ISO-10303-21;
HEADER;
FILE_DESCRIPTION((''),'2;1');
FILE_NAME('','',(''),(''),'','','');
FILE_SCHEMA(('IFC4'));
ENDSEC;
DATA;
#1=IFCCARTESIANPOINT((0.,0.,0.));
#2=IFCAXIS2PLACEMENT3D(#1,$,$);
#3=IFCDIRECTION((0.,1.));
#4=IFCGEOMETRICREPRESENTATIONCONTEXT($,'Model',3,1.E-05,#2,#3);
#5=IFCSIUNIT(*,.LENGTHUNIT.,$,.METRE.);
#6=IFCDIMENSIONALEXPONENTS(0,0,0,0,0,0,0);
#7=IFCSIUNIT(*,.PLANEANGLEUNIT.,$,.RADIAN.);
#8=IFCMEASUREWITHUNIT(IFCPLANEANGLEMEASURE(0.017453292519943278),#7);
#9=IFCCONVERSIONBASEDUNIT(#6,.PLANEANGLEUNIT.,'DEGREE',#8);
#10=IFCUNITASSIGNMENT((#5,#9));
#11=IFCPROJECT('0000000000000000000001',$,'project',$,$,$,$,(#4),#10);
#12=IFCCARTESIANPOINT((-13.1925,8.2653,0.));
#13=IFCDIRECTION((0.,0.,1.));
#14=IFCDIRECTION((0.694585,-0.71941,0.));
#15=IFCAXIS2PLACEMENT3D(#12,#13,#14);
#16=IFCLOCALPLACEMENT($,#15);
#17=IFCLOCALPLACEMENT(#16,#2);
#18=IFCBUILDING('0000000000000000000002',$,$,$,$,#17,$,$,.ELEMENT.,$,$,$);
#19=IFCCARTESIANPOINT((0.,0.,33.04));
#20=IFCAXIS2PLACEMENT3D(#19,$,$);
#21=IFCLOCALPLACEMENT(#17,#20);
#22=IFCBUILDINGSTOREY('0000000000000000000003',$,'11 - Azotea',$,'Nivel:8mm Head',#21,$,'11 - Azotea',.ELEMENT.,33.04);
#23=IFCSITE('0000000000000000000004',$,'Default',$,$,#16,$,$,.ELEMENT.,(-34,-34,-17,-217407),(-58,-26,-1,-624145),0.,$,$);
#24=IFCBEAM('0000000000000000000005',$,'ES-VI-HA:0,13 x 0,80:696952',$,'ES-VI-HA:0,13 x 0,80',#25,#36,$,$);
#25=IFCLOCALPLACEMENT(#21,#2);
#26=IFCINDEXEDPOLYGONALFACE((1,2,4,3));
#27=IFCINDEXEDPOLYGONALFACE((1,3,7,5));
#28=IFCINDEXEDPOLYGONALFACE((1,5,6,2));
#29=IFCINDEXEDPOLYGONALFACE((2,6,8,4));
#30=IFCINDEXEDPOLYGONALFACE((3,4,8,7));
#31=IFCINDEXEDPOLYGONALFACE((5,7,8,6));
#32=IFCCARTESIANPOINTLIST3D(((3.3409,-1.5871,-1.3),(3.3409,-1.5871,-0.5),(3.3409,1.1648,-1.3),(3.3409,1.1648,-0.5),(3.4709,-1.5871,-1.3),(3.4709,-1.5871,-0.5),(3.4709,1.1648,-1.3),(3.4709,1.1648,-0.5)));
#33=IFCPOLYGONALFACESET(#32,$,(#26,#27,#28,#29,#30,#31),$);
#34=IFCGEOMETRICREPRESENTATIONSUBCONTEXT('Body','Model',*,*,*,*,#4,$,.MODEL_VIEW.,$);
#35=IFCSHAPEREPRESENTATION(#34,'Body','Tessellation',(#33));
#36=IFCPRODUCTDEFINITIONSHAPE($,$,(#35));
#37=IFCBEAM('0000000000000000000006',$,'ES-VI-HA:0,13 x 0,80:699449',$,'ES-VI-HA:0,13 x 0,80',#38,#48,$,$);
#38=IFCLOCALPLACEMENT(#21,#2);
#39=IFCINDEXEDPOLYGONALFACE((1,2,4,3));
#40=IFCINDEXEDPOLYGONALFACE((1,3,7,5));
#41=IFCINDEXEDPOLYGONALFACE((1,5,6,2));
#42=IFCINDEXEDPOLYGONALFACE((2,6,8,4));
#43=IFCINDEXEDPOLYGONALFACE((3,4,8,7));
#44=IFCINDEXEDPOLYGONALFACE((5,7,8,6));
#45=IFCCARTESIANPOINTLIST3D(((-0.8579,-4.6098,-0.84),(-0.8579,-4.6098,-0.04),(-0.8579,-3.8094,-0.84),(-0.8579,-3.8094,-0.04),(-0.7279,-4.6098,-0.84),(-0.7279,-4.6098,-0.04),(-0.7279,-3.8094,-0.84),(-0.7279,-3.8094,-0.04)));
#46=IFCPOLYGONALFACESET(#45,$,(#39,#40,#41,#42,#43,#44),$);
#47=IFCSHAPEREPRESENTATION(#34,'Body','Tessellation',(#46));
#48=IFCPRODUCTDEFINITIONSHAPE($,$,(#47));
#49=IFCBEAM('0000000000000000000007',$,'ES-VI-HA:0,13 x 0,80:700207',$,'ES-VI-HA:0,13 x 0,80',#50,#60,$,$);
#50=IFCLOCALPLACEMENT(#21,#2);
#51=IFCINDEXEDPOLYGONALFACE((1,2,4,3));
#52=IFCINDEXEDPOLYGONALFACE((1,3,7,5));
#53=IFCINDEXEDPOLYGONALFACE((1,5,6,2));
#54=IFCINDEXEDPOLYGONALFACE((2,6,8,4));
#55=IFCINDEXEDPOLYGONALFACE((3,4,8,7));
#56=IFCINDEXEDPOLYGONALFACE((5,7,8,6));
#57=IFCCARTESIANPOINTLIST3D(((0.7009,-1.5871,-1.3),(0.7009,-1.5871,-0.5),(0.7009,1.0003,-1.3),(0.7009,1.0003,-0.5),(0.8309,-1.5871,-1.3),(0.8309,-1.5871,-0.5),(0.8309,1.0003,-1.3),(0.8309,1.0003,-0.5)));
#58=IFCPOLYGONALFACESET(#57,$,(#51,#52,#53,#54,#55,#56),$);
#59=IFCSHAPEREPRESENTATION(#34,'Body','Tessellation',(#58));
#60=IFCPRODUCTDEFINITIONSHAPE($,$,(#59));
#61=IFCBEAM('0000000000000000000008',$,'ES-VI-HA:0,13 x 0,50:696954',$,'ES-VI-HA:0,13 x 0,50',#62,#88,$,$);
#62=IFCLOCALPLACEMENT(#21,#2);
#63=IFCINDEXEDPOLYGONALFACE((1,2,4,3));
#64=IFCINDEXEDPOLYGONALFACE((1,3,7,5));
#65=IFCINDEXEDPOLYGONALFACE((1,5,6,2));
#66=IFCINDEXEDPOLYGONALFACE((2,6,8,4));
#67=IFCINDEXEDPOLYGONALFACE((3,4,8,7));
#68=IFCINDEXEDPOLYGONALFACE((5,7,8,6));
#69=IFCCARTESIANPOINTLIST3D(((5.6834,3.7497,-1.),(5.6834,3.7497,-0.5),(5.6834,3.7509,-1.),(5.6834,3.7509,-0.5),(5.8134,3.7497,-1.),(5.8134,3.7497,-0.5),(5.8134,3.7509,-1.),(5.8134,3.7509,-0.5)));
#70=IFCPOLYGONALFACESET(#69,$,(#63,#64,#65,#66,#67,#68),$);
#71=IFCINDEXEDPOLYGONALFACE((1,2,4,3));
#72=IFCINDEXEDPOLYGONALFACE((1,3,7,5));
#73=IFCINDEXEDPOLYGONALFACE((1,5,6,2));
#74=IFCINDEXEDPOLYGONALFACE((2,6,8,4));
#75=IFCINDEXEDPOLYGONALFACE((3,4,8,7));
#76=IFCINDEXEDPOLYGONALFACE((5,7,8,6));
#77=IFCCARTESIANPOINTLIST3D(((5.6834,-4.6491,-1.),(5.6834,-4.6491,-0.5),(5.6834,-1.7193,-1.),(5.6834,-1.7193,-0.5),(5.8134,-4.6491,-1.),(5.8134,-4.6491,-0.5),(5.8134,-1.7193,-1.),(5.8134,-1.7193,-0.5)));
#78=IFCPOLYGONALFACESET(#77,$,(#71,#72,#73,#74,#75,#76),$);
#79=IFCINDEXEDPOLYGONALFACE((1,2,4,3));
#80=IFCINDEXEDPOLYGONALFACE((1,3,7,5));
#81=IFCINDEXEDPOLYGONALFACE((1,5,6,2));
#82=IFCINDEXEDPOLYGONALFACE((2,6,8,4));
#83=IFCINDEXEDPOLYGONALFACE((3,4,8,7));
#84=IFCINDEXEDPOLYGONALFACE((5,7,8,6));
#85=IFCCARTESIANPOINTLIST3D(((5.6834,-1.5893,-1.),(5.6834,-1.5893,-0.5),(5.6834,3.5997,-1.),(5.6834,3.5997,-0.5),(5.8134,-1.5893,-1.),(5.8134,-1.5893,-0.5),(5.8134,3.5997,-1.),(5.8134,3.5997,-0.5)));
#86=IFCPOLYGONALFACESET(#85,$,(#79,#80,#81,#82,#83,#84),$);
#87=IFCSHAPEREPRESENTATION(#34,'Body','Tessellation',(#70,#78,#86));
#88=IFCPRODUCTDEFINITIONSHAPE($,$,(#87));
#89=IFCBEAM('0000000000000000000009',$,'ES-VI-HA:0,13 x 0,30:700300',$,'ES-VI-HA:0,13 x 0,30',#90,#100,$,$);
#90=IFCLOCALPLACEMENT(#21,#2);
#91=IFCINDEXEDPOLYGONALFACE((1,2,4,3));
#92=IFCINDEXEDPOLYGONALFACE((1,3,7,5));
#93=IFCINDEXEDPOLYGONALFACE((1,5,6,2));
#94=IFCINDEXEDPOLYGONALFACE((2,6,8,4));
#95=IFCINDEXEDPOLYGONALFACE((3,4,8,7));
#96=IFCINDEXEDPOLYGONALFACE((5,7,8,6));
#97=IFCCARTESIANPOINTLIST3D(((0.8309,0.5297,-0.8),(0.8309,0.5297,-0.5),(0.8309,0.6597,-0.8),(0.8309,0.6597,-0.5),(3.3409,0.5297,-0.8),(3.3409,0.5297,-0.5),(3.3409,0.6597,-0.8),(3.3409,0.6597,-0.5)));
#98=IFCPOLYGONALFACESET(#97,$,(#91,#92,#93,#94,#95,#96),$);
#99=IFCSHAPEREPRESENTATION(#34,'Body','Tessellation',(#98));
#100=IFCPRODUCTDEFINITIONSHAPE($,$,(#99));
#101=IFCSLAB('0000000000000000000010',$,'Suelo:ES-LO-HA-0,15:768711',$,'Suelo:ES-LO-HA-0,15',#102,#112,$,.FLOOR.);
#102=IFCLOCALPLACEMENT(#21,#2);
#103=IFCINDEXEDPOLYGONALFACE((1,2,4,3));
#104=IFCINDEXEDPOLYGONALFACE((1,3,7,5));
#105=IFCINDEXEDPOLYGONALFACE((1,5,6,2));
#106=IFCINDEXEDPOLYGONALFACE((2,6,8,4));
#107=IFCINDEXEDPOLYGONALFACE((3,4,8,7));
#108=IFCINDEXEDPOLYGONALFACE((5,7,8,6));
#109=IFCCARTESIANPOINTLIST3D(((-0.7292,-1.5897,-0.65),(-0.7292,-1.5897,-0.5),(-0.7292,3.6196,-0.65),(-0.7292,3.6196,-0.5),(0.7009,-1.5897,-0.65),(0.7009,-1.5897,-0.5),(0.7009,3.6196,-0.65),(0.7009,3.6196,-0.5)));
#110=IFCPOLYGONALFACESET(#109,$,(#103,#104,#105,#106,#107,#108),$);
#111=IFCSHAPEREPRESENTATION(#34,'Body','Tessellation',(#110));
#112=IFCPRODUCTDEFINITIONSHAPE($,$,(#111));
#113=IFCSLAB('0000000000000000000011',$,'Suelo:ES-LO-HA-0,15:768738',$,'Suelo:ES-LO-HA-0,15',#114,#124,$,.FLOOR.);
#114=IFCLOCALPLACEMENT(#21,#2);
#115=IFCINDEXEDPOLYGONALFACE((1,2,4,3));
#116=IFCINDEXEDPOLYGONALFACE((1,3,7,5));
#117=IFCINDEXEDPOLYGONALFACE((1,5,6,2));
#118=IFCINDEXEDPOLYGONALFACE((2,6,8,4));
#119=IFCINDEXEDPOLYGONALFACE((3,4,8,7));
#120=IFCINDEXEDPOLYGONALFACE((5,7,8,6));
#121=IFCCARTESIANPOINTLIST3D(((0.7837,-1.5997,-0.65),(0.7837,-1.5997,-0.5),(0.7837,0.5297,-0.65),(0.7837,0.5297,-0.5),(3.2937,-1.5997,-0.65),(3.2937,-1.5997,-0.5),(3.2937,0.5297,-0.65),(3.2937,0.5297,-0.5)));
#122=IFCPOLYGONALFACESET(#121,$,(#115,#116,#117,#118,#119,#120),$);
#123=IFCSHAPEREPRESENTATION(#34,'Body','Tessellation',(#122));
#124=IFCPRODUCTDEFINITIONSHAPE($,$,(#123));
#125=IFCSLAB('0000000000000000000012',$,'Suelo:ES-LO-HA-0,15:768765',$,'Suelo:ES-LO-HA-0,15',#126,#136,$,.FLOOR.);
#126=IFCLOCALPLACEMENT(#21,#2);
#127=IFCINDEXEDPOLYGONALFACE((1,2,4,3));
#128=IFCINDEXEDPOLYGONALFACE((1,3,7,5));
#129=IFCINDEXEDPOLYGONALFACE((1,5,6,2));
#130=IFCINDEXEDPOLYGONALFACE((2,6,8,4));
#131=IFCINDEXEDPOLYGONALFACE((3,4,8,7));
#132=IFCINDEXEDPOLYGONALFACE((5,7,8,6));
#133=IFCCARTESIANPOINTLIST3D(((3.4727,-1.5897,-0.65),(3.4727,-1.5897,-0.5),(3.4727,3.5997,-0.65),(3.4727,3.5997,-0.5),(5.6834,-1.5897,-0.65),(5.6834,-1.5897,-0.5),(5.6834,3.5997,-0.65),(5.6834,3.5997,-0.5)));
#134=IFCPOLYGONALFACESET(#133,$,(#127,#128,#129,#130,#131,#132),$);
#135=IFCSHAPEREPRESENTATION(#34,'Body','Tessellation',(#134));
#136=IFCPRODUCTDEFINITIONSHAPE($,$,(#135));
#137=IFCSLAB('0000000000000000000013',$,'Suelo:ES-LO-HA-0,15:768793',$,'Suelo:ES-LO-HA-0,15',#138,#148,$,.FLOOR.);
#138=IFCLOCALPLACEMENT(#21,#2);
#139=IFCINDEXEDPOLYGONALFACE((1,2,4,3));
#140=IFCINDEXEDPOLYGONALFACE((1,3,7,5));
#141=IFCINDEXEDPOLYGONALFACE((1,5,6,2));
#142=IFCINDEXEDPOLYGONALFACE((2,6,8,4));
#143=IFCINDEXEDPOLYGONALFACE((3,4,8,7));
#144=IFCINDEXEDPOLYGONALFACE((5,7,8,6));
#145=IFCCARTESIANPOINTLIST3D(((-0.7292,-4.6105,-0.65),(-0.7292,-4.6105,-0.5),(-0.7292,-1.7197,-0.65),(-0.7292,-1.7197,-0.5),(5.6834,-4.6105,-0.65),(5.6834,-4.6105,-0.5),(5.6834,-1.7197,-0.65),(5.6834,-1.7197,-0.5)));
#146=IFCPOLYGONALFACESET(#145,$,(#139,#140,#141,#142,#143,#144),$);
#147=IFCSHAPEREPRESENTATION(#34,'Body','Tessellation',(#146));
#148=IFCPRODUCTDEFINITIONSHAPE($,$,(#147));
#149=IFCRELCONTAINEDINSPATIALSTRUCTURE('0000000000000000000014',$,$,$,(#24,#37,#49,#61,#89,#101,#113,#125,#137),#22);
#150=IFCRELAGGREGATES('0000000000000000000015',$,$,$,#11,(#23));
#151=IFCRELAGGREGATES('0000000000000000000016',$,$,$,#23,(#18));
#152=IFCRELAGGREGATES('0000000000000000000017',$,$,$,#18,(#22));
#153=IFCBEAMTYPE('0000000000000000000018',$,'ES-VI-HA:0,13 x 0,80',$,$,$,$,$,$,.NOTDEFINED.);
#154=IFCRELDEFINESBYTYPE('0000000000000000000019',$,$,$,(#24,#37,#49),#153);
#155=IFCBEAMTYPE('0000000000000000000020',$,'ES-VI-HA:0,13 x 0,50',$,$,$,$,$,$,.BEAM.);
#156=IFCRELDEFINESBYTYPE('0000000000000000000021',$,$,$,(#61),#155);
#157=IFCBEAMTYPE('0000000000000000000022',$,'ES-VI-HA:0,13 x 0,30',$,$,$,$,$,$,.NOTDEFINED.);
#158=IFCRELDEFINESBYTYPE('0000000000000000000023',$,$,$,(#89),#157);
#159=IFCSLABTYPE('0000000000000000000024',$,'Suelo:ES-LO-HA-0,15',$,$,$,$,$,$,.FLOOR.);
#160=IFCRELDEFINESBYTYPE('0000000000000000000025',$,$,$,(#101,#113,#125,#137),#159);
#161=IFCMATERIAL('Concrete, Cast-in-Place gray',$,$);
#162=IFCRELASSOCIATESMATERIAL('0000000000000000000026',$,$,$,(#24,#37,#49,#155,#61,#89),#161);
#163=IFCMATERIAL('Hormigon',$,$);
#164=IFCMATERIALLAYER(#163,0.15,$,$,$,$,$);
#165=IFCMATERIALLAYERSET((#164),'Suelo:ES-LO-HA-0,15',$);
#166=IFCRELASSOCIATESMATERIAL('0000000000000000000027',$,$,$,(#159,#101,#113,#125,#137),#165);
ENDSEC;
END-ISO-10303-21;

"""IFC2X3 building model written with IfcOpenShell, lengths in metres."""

from ifc_helpers import new_model, entity, si_unit, converted_unit, direction, frame, frame_2d, origin, origin_2d_with_axis, place, context, subcontext, project, spatial, rectangle, extrude, source, transform, mapped, material, layer, layer_set, layer_usage, type_object, type_shapes, element, save


model = new_model("IFC2X3")

# Units and contexts
model_context = context("Model", 3, precision=1e-05, world=origin(), true_north=direction((0.0, 1.0)))
body_context = subcontext(model_context, "Body", "Model", "MODEL_VIEW")
ifc_project = project(units=[si_unit("LENGTHUNIT", "METRE"), converted_unit("PLANEANGLEUNIT", "DEGREE", entity("IfcPlaneAngleMeasure", 0.017453292519943278), si_unit("PLANEANGLEUNIT", "RADIAN"), dimensions=[0, 0, 0, 0, 0, 0, 0])], contexts=[model_context])

# Site, building, storey
site_placement = place(None, frame((-13.1925, 8.2653, 0.0), z_axis=(0.0, 0.0, 1.0), x_axis=(0.694585, -0.71941, 0.0)))
site = spatial("IfcSite", under=ifc_project, at=site_placement, Name="Default", CompositionType="ELEMENT", RefLatitude=(-34, -34, -17, -217407), RefLongitude=(-58, -26, -1, -624145), RefElevation=0.0)
building_placement = place(site_placement, origin())
building = spatial("IfcBuilding", under=site, at=building_placement, CompositionType="ELEMENT")
storey_placement = place(building_placement, frame((0.0, 0.0, 33.04)))
storey = spatial("IfcBuildingStorey", under=building, at=storey_placement, Name="11 - Azotea", ObjectType="Nivel:8mm Head", LongName="11 - Azotea", CompositionType="ELEMENT", Elevation=33.04)

# Beams
ifc_material_1 = material(Name="Concrete, Cast-in-Place gray")
beam_type_1 = type_object("IfcBeamType", Name="ES-VI-HA:0,13 x 0,80", PredefinedType="NOTDEFINED")
beam_1_placement = place(storey_placement, frame((3.4059, -1.6521, -0.5), z_axis=(0.0, 0.0, 1.0), x_axis=(0.0, 1.0, 0.0)))
element("IfcBeam", 1, at=beam_1_placement, inside=storey, type_object=beam_type_1, material=ifc_material_1, Name="ES-VI-HA:0,13 x 0,80:696952", ObjectType="ES-VI-HA:0,13 x 0,80", context=body_context, shape_type="SweptSolid", body=[
    extrude(rectangle(XDim=0.8, YDim=0.13, at=frame_2d((0.0, 0.0), x_axis=(1.0, 0.0))), frame((0.065, 0.0, -0.4), z_axis=(1.0, 0.0, 0.0), x_axis=(0.0, 0.0, -1.0)), (0.0, 0.0, 1.0), 2.7519),
])
beam_2_placement = place(storey_placement, frame((-0.7929, -3.8094, -0.04), z_axis=(0.0, 0.0, 1.0), x_axis=(0.0, -1.0, 0.0)))
element("IfcBeam", 2, at=beam_2_placement, inside=storey, type_object=beam_type_1, material=ifc_material_1, Name="ES-VI-HA:0,13 x 0,80:699449", ObjectType="ES-VI-HA:0,13 x 0,80", context=body_context, shape_type="SweptSolid", body=[
    extrude(rectangle(XDim=0.8, YDim=0.13, at=frame_2d((0.0, 0.0), x_axis=(1.0, 0.0))), frame((0.0, 0.0, -0.4), z_axis=(1.0, 0.0, 0.0), x_axis=(0.0, 0.0, -1.0)), (0.0, 0.0, 1.0), 0.8004),
])
beam_3_placement = place(storey_placement, frame((0.7659, -1.6521, -0.5), z_axis=(0.0, 0.0, 1.0), x_axis=(0.0, 1.0, 0.0)))
element("IfcBeam", 3, at=beam_3_placement, inside=storey, type_object=beam_type_1, material=ifc_material_1, Name="ES-VI-HA:0,13 x 0,80:700207", ObjectType="ES-VI-HA:0,13 x 0,80", context=body_context, shape_type="SweptSolid", body=[
    extrude(rectangle(XDim=0.8, YDim=0.13, at=origin_2d_with_axis()), frame((0.065, 0.0, -0.4), z_axis=(1.0, 0.0, 0.0), x_axis=(0.0, 0.0, -1.0)), (0.0, 0.0, 1.0), 2.5873),
])
beam_type_2 = type_object("IfcBeamType", Name="ES-VI-HA:0,13 x 0,50", PredefinedType="BEAM", material=ifc_material_1)
shared_shape = source(origin(), body_context, "Body", "SweptSolid", [
    extrude(rectangle(XDim=0.5, YDim=0.13, at=frame_2d((0.0, 0.0), x_axis=(0.0, 1.0))), frame((5.7484, 3.7497, 32.29), z_axis=(0.0, 1.0, 0.0), x_axis=(-1.0, 0.0, 0.0)), (0.0, 0.0, 1.0), 0.0013),
    extrude(rectangle(XDim=0.5, YDim=0.13, at=frame_2d((0.0, 0.0), x_axis=(0.0, 1.0))), frame((5.7484, -4.6491, 32.29), z_axis=(0.0, 1.0, 0.0), x_axis=(-1.0, 0.0, 0.0)), (0.0, 0.0, 1.0), 2.9298),
    extrude(rectangle(XDim=0.5, YDim=0.13, at=frame_2d((0.0, 0.0), x_axis=(0.0, 1.0))), frame((5.7484, -1.5893, 32.29), z_axis=(0.0, 1.0, 0.0), x_axis=(-1.0, 0.0, 0.0)), (0.0, 0.0, 1.0), 5.1889),
])
type_shapes(beam_type_2, [shared_shape])
beam_4_placement = place(storey_placement, frame((0.0, 0.0, -33.04)))
element("IfcBeam", 4, at=beam_4_placement, inside=storey, type_object=beam_type_2, material=ifc_material_1, Name="ES-VI-HA:0,13 x 0,50:696954", ObjectType="ES-VI-HA:0,13 x 0,50", context=body_context, shape_type="MappedRepresentation", body=[
    mapped(shared_shape, transform((0.0, 0.0, 0.0), scale=1.0)),
])
beam_type_3 = type_object("IfcBeamType", Name="ES-VI-HA:0,13 x 0,30", PredefinedType="NOTDEFINED")
beam_5_placement = place(storey_placement, frame((0.7659, 0.5947, -0.5)))
element("IfcBeam", 5, at=beam_5_placement, inside=storey, type_object=beam_type_3, material=ifc_material_1, Name="ES-VI-HA:0,13 x 0,30:700300", ObjectType="ES-VI-HA:0,13 x 0,30", context=body_context, shape_type="SweptSolid", body=[
    extrude(rectangle(XDim=0.3, YDim=0.13, at=frame_2d((0.0, 0.0), x_axis=(1.0, 0.0))), frame((0.065, 0.0, -0.15), z_axis=(1.0, 0.0, 0.0), x_axis=(0.0, 0.0, -1.0)), (0.0, 0.0, 1.0), 2.51),
])

# Slabs
ifc_material_2 = material(Name="Hormigon")
ifc_layer = layer(ifc_material_2, 0.15)
ifc_layer_set = layer_set([ifc_layer], Name="Suelo:ES-LO-HA-0,15")
ifc_layer_usage_1 = layer_usage(ifc_layer_set, "AXIS3", "POSITIVE", 0.0)
slab_type = type_object("IfcSlabType", Name="Suelo:ES-LO-HA-0,15", PredefinedType="FLOOR", material=ifc_layer_set)
slab_1_placement = place(storey_placement, origin())
element("IfcSlab", 6, at=slab_1_placement, inside=storey, type_object=slab_type, material=ifc_layer_usage_1, Name="Suelo:ES-LO-HA-0,15:768711", ObjectType="Suelo:ES-LO-HA-0,15", PredefinedType="FLOOR", context=body_context, shape_type="SweptSolid", body=[
    extrude(rectangle(XDim=5.2093, YDim=1.4301, at=frame_2d((0.0, 0.0), x_axis=(1.0, 0.0))), frame((-0.0142, 1.015, -0.5), z_axis=(0.0, 0.0, -1.0), x_axis=(0.0, 1.0, 0.0)), (0.0, 0.0, 1.0), 0.15),
])
ifc_layer_usage_2 = layer_usage(ifc_layer_set, "AXIS3", "POSITIVE", 0.0)
slab_2_placement = place(storey_placement, origin())
element("IfcSlab", 7, at=slab_2_placement, inside=storey, type_object=slab_type, material=ifc_layer_usage_2, Name="Suelo:ES-LO-HA-0,15:768738", ObjectType="Suelo:ES-LO-HA-0,15", PredefinedType="FLOOR", context=body_context, shape_type="SweptSolid", body=[
    extrude(rectangle(XDim=2.1293, YDim=2.51, at=origin_2d_with_axis()), frame((2.0387, -0.535, -0.5), z_axis=(0.0, 0.0, -1.0), x_axis=(0.0, 1.0, 0.0)), (0.0, 0.0, 1.0), 0.15),
])
ifc_layer_usage_3 = layer_usage(ifc_layer_set, "AXIS3", "POSITIVE", 0.0)
slab_3_placement = place(storey_placement, origin())
element("IfcSlab", 8, at=slab_3_placement, inside=storey, type_object=slab_type, material=ifc_layer_usage_3, Name="Suelo:ES-LO-HA-0,15:768765", ObjectType="Suelo:ES-LO-HA-0,15", PredefinedType="FLOOR", context=body_context, shape_type="SweptSolid", body=[
    extrude(rectangle(XDim=5.1893, YDim=2.2106, at=frame_2d((0.0, 0.0), x_axis=(1.0, 0.0))), frame((4.578, 1.005, -0.5), z_axis=(0.0, 0.0, -1.0), x_axis=(0.0, 1.0, 0.0)), (0.0, 0.0, 1.0), 0.15),
])
ifc_layer_usage_4 = layer_usage(ifc_layer_set, "AXIS3", "POSITIVE", 0.0)
slab_4_placement = place(storey_placement, origin())
element("IfcSlab", 9, at=slab_4_placement, inside=storey, type_object=slab_type, material=ifc_layer_usage_4, Name="Suelo:ES-LO-HA-0,15:768793", ObjectType="Suelo:ES-LO-HA-0,15", PredefinedType="FLOOR", context=body_context, shape_type="SweptSolid", body=[
    extrude(rectangle(XDim=2.8908, YDim=6.4126, at=origin_2d_with_axis()), frame((2.4771, -3.1651, -0.5), z_axis=(0.0, 0.0, -1.0), x_axis=(0.0, 1.0, 0.0)), (0.0, 0.0, 1.0), 0.15),
])

save(model, "model.ifc")
